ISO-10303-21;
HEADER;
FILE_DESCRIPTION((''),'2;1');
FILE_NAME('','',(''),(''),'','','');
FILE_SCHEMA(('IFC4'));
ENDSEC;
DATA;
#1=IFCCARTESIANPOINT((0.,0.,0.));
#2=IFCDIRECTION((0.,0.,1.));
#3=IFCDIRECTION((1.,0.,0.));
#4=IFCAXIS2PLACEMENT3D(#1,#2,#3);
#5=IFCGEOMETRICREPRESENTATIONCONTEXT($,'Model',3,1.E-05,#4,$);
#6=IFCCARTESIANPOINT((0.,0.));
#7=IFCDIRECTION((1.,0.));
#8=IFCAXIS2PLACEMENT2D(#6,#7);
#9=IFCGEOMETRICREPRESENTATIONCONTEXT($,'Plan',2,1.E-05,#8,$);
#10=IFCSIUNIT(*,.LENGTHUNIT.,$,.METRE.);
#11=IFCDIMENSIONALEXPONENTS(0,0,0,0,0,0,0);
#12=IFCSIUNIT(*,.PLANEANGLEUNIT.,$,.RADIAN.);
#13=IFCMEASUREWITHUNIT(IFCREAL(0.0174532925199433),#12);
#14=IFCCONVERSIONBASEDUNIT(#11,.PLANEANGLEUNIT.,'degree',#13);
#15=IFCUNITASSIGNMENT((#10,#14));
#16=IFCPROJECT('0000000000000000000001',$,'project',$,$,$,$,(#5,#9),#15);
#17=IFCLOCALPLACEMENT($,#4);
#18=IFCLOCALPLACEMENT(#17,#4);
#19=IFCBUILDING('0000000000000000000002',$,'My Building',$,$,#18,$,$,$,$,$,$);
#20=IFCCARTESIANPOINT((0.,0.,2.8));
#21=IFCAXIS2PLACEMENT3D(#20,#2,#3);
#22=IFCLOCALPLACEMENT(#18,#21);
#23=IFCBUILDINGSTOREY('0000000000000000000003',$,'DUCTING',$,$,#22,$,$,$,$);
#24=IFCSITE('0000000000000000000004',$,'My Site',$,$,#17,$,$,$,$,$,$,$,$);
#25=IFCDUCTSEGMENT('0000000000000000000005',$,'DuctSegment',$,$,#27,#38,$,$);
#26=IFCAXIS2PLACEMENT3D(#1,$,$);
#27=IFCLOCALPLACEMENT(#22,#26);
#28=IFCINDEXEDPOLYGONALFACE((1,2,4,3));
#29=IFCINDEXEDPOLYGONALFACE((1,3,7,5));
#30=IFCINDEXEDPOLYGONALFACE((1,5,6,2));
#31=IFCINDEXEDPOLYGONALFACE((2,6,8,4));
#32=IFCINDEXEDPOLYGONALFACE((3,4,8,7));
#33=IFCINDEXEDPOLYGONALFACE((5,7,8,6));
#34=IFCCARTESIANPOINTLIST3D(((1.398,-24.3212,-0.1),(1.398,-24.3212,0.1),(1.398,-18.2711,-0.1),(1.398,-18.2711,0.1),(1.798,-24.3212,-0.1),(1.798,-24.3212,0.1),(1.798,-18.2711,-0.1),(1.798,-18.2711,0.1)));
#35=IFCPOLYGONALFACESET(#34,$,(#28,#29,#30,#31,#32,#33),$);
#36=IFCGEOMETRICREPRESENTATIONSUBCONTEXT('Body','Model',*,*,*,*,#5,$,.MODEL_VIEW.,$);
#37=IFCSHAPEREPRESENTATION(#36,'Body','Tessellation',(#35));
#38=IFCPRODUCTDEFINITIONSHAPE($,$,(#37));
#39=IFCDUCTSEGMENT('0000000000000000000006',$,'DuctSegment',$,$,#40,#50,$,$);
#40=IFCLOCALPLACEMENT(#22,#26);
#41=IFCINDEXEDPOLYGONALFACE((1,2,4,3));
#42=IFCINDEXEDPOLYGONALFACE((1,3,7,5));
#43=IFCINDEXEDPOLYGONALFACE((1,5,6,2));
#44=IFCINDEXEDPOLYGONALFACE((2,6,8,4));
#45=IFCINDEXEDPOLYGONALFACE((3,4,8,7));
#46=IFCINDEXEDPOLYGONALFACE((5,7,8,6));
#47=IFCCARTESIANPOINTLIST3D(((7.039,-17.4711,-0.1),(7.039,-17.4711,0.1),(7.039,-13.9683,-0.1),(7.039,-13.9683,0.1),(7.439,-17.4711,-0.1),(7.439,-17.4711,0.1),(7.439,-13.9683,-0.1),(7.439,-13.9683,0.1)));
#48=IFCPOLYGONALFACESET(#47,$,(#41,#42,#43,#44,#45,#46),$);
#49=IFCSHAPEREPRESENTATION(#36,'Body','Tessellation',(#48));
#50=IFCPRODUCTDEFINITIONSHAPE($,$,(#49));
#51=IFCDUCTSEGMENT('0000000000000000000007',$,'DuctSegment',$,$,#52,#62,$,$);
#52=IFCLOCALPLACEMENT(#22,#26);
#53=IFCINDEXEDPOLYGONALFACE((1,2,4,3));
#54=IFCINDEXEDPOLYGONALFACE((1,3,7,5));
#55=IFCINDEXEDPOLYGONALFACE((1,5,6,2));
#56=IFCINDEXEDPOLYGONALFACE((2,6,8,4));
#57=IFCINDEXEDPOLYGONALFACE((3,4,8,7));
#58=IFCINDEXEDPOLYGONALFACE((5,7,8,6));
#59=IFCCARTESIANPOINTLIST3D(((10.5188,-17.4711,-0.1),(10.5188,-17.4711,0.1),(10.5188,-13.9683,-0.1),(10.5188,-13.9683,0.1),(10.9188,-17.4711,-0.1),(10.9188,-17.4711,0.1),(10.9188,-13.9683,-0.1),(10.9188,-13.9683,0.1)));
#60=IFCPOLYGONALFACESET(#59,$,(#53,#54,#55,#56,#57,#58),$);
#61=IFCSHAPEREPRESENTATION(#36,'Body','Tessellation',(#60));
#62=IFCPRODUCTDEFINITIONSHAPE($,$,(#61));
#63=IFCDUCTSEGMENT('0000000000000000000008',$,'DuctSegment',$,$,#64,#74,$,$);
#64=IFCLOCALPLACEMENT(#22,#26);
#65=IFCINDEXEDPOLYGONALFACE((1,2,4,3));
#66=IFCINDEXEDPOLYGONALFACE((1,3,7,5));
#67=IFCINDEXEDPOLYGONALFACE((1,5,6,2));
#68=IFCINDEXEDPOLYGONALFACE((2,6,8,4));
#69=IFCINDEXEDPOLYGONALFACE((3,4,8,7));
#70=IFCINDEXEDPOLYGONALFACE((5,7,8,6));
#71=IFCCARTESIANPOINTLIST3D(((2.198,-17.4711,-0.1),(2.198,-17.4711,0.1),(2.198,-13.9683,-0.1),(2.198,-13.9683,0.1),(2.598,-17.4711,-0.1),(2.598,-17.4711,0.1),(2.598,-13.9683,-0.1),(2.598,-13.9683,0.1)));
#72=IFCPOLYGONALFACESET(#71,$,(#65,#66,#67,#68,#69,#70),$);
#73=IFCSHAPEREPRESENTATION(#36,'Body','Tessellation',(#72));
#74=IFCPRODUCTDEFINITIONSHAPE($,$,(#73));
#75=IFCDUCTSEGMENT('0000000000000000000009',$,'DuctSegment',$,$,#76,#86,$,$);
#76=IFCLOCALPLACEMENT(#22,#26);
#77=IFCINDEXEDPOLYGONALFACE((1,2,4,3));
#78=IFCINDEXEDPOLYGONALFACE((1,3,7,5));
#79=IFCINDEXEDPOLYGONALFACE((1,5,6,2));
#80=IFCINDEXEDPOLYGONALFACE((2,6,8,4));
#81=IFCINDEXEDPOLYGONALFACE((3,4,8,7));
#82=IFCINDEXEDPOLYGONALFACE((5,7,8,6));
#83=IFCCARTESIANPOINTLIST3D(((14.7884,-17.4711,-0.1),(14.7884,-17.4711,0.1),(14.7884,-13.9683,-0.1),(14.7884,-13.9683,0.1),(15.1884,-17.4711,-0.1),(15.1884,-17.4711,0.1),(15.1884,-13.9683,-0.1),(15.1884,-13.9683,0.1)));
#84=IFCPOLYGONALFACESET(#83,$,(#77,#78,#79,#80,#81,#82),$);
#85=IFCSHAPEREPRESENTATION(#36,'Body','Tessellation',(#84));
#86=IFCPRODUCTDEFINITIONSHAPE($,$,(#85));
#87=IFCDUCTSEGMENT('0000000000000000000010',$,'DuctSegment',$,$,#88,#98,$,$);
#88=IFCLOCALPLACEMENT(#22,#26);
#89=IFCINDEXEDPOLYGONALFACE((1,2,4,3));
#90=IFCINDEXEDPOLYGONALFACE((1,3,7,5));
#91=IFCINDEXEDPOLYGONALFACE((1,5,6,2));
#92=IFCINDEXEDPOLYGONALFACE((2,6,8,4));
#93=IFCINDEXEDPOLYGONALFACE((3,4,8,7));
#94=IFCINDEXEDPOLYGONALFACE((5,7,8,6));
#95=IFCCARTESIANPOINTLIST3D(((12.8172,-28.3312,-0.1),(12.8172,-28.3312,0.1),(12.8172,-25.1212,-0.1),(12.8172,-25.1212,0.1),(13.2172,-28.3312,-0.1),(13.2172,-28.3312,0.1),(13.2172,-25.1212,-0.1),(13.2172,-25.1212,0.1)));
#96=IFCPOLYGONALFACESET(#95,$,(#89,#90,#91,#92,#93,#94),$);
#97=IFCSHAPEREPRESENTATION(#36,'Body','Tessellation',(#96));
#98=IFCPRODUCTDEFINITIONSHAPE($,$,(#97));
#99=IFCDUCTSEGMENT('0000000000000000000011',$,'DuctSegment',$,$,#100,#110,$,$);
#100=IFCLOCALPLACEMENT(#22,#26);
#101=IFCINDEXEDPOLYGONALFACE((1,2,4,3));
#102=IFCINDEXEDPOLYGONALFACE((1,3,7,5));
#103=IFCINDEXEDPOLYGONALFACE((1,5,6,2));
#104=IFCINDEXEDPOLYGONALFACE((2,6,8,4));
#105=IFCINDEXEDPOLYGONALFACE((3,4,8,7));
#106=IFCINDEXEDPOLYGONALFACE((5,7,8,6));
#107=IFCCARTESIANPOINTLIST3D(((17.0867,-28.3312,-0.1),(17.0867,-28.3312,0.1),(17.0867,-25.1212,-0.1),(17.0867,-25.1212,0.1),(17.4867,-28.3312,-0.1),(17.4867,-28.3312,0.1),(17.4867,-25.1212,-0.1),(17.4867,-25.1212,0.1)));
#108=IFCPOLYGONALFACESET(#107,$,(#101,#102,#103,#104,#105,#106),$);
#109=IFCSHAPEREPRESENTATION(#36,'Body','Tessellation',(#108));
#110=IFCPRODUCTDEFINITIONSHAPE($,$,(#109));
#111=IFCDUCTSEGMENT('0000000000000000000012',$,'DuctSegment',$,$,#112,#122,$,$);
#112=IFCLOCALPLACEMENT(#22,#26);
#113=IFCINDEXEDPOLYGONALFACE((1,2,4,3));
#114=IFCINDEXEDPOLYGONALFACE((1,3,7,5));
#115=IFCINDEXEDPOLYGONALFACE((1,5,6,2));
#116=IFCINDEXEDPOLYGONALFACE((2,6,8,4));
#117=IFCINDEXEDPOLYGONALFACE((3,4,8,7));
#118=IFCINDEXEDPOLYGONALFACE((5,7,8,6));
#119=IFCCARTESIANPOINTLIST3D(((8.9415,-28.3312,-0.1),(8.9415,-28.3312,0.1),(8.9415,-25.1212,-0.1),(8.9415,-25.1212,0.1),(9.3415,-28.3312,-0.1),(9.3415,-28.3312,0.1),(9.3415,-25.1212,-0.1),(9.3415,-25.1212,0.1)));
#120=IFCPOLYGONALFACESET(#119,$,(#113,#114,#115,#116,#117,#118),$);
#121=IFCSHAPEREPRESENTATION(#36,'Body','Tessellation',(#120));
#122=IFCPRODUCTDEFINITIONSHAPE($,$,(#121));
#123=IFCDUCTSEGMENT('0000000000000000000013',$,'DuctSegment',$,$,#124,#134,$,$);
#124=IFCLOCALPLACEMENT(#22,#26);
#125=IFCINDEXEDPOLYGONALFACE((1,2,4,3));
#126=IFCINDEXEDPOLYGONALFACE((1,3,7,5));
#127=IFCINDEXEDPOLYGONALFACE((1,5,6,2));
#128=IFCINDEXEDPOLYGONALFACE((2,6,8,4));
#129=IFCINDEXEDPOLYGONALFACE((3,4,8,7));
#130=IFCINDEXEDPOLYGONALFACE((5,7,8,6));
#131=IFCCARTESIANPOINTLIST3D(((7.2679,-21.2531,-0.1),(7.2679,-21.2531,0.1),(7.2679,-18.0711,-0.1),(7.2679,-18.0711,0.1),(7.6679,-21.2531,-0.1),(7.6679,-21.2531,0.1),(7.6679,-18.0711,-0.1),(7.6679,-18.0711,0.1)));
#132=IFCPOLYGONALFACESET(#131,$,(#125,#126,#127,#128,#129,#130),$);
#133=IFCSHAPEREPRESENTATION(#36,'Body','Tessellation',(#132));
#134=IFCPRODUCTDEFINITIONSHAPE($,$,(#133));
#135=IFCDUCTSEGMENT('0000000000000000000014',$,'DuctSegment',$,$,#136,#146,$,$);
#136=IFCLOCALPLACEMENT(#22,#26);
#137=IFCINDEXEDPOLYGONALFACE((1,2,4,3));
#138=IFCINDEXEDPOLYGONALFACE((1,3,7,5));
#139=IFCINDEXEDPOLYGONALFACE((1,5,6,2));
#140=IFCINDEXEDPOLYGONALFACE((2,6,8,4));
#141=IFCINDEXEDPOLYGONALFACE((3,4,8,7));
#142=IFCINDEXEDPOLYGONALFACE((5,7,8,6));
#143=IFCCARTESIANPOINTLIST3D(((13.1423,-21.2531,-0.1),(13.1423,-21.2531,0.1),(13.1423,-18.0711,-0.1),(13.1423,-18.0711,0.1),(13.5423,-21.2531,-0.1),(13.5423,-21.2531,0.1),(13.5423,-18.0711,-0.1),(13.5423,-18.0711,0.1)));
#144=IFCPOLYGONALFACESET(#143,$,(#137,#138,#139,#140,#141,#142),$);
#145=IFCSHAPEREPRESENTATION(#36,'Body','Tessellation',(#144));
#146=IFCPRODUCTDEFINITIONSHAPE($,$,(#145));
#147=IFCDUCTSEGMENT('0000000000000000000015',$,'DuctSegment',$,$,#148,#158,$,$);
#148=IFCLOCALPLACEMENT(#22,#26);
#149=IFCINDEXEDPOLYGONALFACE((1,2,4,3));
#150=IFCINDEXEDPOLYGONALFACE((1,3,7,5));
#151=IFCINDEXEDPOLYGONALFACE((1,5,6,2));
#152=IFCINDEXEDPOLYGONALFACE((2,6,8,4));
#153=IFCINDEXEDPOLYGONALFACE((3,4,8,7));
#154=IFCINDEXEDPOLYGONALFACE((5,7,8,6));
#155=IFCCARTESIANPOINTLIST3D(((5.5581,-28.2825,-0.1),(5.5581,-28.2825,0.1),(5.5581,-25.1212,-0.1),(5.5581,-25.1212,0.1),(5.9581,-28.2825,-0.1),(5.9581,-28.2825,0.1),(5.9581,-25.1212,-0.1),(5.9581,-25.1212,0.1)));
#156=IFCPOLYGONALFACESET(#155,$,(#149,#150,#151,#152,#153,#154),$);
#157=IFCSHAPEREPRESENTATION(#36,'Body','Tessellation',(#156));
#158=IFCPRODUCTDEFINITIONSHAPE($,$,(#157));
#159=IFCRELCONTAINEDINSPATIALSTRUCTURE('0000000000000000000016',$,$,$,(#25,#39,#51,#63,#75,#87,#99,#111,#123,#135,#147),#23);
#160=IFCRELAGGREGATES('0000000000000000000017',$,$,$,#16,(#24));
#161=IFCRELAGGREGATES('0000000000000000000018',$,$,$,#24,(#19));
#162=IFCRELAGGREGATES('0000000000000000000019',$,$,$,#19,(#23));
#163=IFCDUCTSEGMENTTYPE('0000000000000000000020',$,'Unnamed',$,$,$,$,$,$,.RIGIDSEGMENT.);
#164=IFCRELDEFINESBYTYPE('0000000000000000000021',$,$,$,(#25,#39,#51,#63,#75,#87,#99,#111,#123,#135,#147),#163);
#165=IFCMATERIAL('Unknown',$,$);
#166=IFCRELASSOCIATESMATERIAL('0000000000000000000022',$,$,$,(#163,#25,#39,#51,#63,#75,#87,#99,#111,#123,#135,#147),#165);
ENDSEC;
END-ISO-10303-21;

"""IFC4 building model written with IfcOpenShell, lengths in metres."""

from ifc_helpers import new_model, entity, si_unit, converted_unit, frame, origin_with_axes, origin_2d_with_axis, place, context, subcontext, project, spatial, rectangle, extrude, material, material_profile, profile_set, profile_usage, type_object, element, save


model = new_model("IFC4")

# Units and contexts
model_context = context("Model", 3, precision=1e-05, world=origin_with_axes())
plan_context = context("Plan", 2, precision=1e-05, world=origin_2d_with_axis())
body_context = subcontext(model_context, "Body", "Model", "MODEL_VIEW")
ifc_project = project(units=[si_unit("LENGTHUNIT", "METRE"), converted_unit("PLANEANGLEUNIT", "degree", entity("IfcReal", 0.0174532925199433), si_unit("PLANEANGLEUNIT", "RADIAN"), dimensions=[0, 0, 0, 0, 0, 0, 0])], contexts=[model_context, plan_context])

# Site, building, storey
site_placement = place(None, origin_with_axes())
site = spatial("IfcSite", under=ifc_project, at=site_placement, Name="My Site")
building_placement = place(site_placement, origin_with_axes())
building = spatial("IfcBuilding", under=site, at=building_placement, Name="My Building")
storey_placement = place(building_placement, frame((0.0, 0.0, 2.8), z_axis=(0.0, 0.0, 1.0), x_axis=(1.0, 0.0, 0.0)))
storey = spatial("IfcBuildingStorey", under=building, at=storey_placement, Name="DUCTING")

# Duct segments
ifc_material = material(Name="Unknown")
ifc_material_profile_1 = material_profile(ifc_material, rectangle(XDim=0.4, YDim=0.2))
ifc_profile_set_1 = profile_set([ifc_material_profile_1])
ifc_profile_usage_1 = profile_usage(ifc_profile_set_1, cardinal=5)
duct_segment_type = type_object("IfcDuctSegmentType", Name="Unnamed", PredefinedType="RIGIDSEGMENT", material=ifc_profile_set_1)
duct_segment_1_placement = place(storey_placement, frame((1.598, -18.2711, 0.0), z_axis=(0.0, -1.0, 0.0), x_axis=(-1.0, 0.0, 0.0)))
element("IfcDuctSegment", 1, at=duct_segment_1_placement, inside=storey, type_object=duct_segment_type, material=ifc_profile_usage_1, Name="DuctSegment", context=body_context, shape_type="SweptSolid", body=[
    extrude(rectangle(XDim=0.4, YDim=0.2), origin_with_axes(), (0.0, 0.0, 1.0), 6.0502),
])
ifc_profile_usage_2 = profile_usage(ifc_profile_set_1, cardinal=5)
duct_segment_2_placement = place(storey_placement, frame((7.239, -13.9683, 0.0), z_axis=(0.0, -1.0, 0.0), x_axis=(1.0, 0.0, 0.0)))
element("IfcDuctSegment", 2, at=duct_segment_2_placement, inside=storey, type_object=duct_segment_type, material=ifc_profile_usage_2, Name="DuctSegment", context=body_context, shape_type="SweptSolid", body=[
    extrude(rectangle(XDim=0.4, YDim=0.2), origin_with_axes(), (0.0, 0.0, 1.0), 3.5028),
])
ifc_profile_usage_3 = profile_usage(ifc_profile_set_1, cardinal=5)
duct_segment_3_placement = place(storey_placement, frame((10.7188, -13.9683, 0.0), z_axis=(0.0, -1.0, 0.0), x_axis=(1.0, 0.0, 0.0)))
element("IfcDuctSegment", 3, at=duct_segment_3_placement, inside=storey, type_object=duct_segment_type, material=ifc_profile_usage_3, Name="DuctSegment", context=body_context, shape_type="SweptSolid", body=[
    extrude(rectangle(XDim=0.4, YDim=0.2), origin_with_axes(), (0.0, 0.0, 1.0), 3.5028),
])
ifc_profile_usage_4 = profile_usage(ifc_profile_set_1, cardinal=5)
duct_segment_4_placement = place(storey_placement, frame((2.398, -13.9683, 0.0), z_axis=(0.0, -1.0, 0.0), x_axis=(1.0, 0.0, 0.0)))
element("IfcDuctSegment", 4, at=duct_segment_4_placement, inside=storey, type_object=duct_segment_type, material=ifc_profile_usage_4, Name="DuctSegment", context=body_context, shape_type="SweptSolid", body=[
    extrude(rectangle(XDim=0.4, YDim=0.2), origin_with_axes(), (0.0, 0.0, 1.0), 3.5028),
])
ifc_profile_usage_5 = profile_usage(ifc_profile_set_1, cardinal=5)
duct_segment_5_placement = place(storey_placement, frame((14.9884, -13.9683, 0.0), z_axis=(0.0, -1.0, 0.0), x_axis=(1.0, 0.0, 0.0)))
element("IfcDuctSegment", 5, at=duct_segment_5_placement, inside=storey, type_object=duct_segment_type, material=ifc_profile_usage_5, Name="DuctSegment", context=body_context, shape_type="SweptSolid", body=[
    extrude(rectangle(XDim=0.4, YDim=0.2), origin_with_axes(), (0.0, 0.0, 1.0), 3.5028),
])
ifc_profile_usage_6 = profile_usage(ifc_profile_set_1, cardinal=5)
duct_segment_6_placement = place(storey_placement, frame((13.0172, -28.3312, 0.0), z_axis=(0.0, 1.0, 0.0), x_axis=(-1.0, 0.0, 0.0)))
element("IfcDuctSegment", 6, at=duct_segment_6_placement, inside=storey, type_object=duct_segment_type, material=ifc_profile_usage_6, Name="DuctSegment", context=body_context, shape_type="SweptSolid", body=[
    extrude(rectangle(XDim=0.4, YDim=0.2), origin_with_axes(), (0.0, 0.0, 1.0), 3.2099),
])
ifc_profile_usage_7 = profile_usage(ifc_profile_set_1, cardinal=5)
duct_segment_7_placement = place(storey_placement, frame((17.2867, -28.3312, 0.0), z_axis=(0.0, 1.0, 0.0), x_axis=(-1.0, 0.0, 0.0)))
element("IfcDuctSegment", 7, at=duct_segment_7_placement, inside=storey, type_object=duct_segment_type, material=ifc_profile_usage_7, Name="DuctSegment", context=body_context, shape_type="SweptSolid", body=[
    extrude(rectangle(XDim=0.4, YDim=0.2), origin_with_axes(), (0.0, 0.0, 1.0), 3.2099),
])
ifc_profile_usage_8 = profile_usage(ifc_profile_set_1, cardinal=5)
duct_segment_8_placement = place(storey_placement, frame((9.1415, -28.3312, 0.0), z_axis=(0.0, 1.0, 0.0), x_axis=(-1.0, 0.0, 0.0)))
element("IfcDuctSegment", 8, at=duct_segment_8_placement, inside=storey, type_object=duct_segment_type, material=ifc_profile_usage_8, Name="DuctSegment", context=body_context, shape_type="SweptSolid", body=[
    extrude(rectangle(XDim=0.4, YDim=0.2), origin_with_axes(), (0.0, 0.0, 1.0), 3.2099),
])
ifc_profile_usage_9 = profile_usage(ifc_profile_set_1, cardinal=5)
duct_segment_9_placement = place(storey_placement, frame((7.4679, -21.2531, 0.0), z_axis=(0.0, 1.0, 0.0), x_axis=(-1.0, 0.0, 0.0)))
element("IfcDuctSegment", 9, at=duct_segment_9_placement, inside=storey, type_object=duct_segment_type, material=ifc_profile_usage_9, Name="DuctSegment", context=body_context, shape_type="SweptSolid", body=[
    extrude(rectangle(XDim=0.4, YDim=0.2), origin_with_axes(), (0.0, 0.0, 1.0), 3.1821),
])
ifc_profile_usage_10 = profile_usage(ifc_profile_set_1, cardinal=5)
duct_segment_10_placement = place(storey_placement, frame((13.3423, -21.2531, 0.0), z_axis=(0.0, 1.0, 0.0), x_axis=(-1.0, 0.0, 0.0)))
element("IfcDuctSegment", 10, at=duct_segment_10_placement, inside=storey, type_object=duct_segment_type, material=ifc_profile_usage_10, Name="DuctSegment", context=body_context, shape_type="SweptSolid", body=[
    extrude(rectangle(XDim=0.4, YDim=0.2), origin_with_axes(), (0.0, 0.0, 1.0), 3.1821),
])
ifc_profile_usage_11 = profile_usage(ifc_profile_set_1, cardinal=5)
duct_segment_11_placement = place(storey_placement, frame((5.7581, -28.2825, 0.0), z_axis=(0.0, 1.0, 0.0), x_axis=(-1.0, 0.0, 0.0)))
element("IfcDuctSegment", 11, at=duct_segment_11_placement, inside=storey, type_object=duct_segment_type, material=ifc_profile_usage_11, Name="DuctSegment", context=body_context, shape_type="SweptSolid", body=[
    extrude(rectangle(XDim=0.4, YDim=0.2), origin_with_axes(), (0.0, 0.0, 1.0), 3.1613),
])

save(model, "model.ifc")
